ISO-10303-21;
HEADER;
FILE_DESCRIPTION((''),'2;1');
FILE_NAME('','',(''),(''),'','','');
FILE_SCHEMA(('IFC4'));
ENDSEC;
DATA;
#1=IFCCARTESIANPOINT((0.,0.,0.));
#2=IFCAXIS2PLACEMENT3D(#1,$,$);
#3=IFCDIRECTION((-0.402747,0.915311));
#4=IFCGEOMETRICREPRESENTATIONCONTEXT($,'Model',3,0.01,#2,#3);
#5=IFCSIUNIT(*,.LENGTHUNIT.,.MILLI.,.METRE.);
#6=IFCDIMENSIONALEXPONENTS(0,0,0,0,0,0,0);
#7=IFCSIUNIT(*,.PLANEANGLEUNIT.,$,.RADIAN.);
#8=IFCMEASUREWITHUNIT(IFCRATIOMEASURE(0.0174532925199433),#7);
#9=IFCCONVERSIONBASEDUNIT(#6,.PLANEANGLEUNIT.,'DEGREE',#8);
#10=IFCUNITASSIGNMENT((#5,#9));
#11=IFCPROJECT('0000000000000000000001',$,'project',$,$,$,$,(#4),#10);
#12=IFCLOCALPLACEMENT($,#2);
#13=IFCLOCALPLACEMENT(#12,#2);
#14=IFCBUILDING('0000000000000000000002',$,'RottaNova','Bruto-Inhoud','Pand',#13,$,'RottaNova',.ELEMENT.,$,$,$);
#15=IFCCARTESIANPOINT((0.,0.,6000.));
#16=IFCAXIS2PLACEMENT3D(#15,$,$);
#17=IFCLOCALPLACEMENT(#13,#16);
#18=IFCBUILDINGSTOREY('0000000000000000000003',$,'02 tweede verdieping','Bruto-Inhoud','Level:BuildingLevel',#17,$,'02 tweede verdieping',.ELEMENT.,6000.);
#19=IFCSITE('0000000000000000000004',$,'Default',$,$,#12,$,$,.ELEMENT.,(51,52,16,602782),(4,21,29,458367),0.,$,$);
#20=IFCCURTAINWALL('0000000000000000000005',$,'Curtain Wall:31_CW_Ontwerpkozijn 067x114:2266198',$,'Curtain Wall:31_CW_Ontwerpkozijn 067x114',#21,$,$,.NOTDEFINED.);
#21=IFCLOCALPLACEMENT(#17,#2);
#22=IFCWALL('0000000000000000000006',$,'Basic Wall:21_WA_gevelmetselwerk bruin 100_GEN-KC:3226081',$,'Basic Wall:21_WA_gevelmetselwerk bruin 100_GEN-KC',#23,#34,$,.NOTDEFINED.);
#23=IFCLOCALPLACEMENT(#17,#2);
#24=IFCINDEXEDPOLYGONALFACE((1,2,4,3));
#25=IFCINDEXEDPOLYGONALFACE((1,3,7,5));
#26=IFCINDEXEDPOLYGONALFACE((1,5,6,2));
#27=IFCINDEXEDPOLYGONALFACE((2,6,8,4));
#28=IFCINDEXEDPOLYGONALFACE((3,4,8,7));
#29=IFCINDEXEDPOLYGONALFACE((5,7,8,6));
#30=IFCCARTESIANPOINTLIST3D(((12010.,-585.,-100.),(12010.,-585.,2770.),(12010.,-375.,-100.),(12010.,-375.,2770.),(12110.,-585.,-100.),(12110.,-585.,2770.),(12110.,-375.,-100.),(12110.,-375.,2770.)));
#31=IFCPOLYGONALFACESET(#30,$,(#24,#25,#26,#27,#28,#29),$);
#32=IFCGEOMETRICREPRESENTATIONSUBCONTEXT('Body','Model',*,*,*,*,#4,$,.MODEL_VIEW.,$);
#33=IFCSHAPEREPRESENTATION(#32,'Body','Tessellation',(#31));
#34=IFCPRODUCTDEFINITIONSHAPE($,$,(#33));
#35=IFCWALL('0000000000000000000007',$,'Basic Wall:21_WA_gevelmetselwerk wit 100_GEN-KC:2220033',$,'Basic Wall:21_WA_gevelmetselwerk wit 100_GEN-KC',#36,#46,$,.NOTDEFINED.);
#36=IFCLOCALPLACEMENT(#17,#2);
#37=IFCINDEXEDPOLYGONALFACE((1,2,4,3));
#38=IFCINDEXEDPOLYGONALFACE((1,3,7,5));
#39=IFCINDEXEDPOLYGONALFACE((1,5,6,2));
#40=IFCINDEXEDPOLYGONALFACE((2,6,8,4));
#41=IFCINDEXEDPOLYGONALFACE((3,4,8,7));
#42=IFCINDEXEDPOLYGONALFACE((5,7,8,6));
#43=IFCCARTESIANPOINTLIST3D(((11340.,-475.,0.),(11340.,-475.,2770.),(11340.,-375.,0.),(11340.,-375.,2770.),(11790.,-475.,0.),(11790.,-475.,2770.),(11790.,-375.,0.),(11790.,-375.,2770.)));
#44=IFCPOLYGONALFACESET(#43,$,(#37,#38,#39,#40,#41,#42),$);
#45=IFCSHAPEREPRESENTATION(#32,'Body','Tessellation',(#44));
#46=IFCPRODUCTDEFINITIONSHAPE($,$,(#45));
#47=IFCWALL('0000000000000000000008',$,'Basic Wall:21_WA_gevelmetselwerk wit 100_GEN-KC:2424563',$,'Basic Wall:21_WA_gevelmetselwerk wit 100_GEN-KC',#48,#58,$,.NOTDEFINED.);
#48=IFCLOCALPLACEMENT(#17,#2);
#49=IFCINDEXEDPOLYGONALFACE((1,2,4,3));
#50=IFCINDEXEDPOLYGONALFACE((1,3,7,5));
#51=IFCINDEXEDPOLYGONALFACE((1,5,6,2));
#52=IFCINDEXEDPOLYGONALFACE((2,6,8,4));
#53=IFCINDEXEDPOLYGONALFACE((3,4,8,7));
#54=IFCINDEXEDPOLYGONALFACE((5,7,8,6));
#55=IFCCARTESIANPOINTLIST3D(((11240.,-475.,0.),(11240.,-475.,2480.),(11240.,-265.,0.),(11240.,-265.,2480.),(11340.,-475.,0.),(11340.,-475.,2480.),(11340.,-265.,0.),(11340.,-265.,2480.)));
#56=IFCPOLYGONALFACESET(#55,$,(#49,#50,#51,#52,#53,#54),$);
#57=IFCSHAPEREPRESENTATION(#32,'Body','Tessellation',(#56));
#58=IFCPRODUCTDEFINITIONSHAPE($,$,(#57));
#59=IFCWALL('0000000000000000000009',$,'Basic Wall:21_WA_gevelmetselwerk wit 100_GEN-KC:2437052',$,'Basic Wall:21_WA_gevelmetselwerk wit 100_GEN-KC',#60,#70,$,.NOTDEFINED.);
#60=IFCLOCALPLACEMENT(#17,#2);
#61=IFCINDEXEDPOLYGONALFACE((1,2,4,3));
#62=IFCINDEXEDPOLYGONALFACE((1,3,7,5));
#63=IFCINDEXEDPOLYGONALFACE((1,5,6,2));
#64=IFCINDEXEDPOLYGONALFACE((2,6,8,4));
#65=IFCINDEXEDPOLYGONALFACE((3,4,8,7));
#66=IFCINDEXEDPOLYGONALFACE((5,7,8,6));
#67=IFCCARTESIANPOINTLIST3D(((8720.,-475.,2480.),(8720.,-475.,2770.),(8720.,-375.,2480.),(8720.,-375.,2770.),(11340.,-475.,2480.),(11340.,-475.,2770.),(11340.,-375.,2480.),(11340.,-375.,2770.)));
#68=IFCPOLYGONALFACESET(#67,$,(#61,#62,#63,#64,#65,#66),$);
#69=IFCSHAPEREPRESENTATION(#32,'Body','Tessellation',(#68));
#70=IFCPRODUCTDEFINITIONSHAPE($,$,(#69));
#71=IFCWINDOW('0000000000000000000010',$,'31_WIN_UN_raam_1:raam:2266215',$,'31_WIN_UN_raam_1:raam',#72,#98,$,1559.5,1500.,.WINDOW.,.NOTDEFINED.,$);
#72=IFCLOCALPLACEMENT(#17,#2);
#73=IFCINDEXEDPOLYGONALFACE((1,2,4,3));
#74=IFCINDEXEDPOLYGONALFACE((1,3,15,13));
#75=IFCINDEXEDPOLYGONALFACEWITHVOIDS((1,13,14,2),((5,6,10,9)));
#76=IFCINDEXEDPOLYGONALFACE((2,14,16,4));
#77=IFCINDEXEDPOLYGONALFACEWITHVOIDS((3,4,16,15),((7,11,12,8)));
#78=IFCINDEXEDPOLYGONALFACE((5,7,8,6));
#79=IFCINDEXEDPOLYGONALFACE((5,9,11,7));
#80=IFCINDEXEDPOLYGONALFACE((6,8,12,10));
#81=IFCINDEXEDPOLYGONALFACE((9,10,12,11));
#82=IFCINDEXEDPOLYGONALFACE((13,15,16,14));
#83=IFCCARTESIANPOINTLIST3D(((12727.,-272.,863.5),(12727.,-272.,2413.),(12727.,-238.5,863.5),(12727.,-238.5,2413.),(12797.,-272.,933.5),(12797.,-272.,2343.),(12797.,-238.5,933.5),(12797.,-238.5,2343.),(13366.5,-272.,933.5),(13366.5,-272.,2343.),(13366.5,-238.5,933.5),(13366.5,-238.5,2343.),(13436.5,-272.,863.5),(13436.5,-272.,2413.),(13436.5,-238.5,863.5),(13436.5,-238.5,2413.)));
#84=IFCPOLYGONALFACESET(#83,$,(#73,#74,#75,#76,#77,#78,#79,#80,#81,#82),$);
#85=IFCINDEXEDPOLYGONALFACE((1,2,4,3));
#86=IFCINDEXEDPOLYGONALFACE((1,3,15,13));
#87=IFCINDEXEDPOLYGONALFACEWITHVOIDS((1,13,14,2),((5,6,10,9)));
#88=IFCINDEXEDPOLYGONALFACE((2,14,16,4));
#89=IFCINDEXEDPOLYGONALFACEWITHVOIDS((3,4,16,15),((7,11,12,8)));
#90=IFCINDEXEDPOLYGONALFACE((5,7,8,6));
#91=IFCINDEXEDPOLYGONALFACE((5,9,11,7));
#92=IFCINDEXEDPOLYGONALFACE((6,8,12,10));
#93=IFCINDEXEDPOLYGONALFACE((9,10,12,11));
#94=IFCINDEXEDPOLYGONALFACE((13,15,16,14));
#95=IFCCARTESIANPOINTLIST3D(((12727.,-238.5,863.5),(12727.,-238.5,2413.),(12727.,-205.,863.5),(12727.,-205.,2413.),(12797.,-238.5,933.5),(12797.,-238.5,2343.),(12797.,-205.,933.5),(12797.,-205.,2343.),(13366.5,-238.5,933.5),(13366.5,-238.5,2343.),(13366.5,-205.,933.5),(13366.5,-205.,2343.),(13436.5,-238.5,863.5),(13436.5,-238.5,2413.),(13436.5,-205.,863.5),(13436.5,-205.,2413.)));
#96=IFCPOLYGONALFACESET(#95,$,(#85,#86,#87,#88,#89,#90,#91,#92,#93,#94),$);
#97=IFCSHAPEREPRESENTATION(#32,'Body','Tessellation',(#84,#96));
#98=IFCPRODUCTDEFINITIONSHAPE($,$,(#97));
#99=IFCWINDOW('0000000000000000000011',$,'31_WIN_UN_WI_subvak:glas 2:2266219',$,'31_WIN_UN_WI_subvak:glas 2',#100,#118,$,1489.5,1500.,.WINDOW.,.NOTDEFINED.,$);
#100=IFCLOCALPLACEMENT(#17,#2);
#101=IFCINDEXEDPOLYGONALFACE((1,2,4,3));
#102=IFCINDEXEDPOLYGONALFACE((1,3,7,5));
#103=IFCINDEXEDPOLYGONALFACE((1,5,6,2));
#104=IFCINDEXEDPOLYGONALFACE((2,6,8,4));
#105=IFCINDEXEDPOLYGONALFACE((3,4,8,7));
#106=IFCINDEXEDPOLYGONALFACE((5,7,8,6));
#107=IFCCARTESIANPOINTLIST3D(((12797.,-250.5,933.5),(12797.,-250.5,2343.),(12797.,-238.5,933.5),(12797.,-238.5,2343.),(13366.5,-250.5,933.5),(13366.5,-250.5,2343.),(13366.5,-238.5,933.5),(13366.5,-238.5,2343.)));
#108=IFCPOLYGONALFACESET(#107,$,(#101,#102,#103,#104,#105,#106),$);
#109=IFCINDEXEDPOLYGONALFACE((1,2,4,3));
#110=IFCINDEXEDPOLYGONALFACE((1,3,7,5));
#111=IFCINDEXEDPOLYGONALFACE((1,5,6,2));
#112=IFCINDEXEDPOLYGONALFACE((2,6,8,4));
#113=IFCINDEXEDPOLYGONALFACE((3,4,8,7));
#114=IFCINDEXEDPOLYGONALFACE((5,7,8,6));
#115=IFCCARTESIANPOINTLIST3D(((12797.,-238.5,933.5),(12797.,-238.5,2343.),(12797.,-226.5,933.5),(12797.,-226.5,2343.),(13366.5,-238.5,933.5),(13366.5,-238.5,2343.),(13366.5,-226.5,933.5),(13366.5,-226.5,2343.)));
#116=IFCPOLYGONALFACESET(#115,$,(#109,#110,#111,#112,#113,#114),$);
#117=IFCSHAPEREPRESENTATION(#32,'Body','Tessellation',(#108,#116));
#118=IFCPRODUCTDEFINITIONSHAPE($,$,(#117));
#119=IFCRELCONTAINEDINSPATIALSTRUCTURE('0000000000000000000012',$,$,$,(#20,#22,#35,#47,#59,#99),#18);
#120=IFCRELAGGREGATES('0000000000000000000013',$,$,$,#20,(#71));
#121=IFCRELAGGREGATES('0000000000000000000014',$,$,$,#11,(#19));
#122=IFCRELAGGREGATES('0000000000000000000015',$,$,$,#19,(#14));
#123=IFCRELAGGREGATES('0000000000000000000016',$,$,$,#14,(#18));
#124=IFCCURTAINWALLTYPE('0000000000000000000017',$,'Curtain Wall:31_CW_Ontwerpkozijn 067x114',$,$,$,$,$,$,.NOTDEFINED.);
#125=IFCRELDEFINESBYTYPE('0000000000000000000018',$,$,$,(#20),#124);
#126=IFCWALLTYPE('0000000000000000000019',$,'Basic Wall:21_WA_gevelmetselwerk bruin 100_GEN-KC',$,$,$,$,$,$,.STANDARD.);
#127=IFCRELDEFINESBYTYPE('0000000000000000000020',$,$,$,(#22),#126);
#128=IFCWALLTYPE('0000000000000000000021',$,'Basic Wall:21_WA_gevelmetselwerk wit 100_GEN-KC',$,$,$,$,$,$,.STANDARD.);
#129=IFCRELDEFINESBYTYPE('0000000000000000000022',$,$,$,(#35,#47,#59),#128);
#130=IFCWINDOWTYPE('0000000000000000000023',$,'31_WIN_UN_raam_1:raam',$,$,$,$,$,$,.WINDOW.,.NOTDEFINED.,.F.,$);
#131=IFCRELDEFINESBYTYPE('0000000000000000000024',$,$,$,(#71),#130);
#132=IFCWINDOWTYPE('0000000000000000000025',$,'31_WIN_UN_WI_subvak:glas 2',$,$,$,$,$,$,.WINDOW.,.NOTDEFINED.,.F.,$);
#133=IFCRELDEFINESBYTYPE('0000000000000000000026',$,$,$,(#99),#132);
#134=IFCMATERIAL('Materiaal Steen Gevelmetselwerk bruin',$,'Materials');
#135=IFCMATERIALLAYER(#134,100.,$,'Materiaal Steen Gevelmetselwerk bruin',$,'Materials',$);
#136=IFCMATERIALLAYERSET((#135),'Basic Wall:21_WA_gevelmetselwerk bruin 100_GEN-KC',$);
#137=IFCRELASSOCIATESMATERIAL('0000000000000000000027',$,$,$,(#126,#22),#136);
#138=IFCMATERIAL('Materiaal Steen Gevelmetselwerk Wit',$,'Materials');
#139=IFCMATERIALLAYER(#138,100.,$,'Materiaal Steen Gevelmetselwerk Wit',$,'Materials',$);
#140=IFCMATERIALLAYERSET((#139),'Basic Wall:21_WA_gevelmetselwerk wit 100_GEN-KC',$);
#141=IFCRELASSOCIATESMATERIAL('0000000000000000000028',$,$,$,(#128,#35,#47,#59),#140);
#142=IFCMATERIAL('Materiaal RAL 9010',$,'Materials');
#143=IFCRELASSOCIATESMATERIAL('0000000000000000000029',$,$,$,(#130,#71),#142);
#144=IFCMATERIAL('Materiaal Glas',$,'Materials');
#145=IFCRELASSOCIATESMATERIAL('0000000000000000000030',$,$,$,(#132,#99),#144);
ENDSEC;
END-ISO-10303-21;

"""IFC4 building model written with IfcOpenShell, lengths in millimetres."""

from ifc_helpers import new_model, entity, si_unit, converted_unit, direction, frame, frame_2d, origin, origin_2d_with_axis, place, context, subcontext, project, spatial, polyline, rectangle, outline, extrude, clip, bounded_halfspace, source, transform, mapped, material, layer, layer_set, type_object, type_shapes, element, aggregate, save


model = new_model("IFC4")

# Units and contexts
model_context = context("Model", 3, precision=0.01, world=origin(), true_north=direction((-0.402747, 0.915311)))
body_context = subcontext(model_context, "Body", "Model", "MODEL_VIEW")
ifc_project = project(units=[si_unit("LENGTHUNIT", "METRE", prefix="MILLI"), converted_unit("PLANEANGLEUNIT", "DEGREE", entity("IfcRatioMeasure", 0.0174532925199433), si_unit("PLANEANGLEUNIT", "RADIAN"), dimensions=[0, 0, 0, 0, 0, 0, 0])], contexts=[model_context])

# Site, building, storey
site_placement = place(None, origin())
site = spatial("IfcSite", under=ifc_project, at=site_placement, Name="Default", CompositionType="ELEMENT", RefLatitude=(51, 52, 16, 602782), RefLongitude=(4, 21, 29, 458367), RefElevation=0.0)
building_placement = place(site_placement, origin())
building = spatial("IfcBuilding", under=site, at=building_placement, Name="RottaNova", Description="Bruto-Inhoud", ObjectType="Pand", LongName="RottaNova", CompositionType="ELEMENT")
storey_placement = place(building_placement, frame((0.0, 0.0, 6000.0)))
storey = spatial("IfcBuildingStorey", under=building, at=storey_placement, Name="02 tweede verdieping", Description="Bruto-Inhoud", ObjectType="Level:BuildingLevel", LongName="02 tweede verdieping", CompositionType="ELEMENT", Elevation=6000.0)

# Curtain wall
curtain_wall_type = type_object("IfcCurtainWallType", Name="Curtain Wall:31_CW_Ontwerpkozijn 067x114", PredefinedType="NOTDEFINED")
curtain_wall_1_placement = place(storey_placement, frame((0.0, 0.0, -6000.0)))
curtain_wall_1 = element("IfcCurtainWall", 1, at=curtain_wall_1_placement, inside=storey, type_object=curtain_wall_type, Name="Curtain Wall:31_CW_Ontwerpkozijn 067x114:2266198", ObjectType="Curtain Wall:31_CW_Ontwerpkozijn 067x114", PredefinedType="NOTDEFINED")
ifc_material_1 = material(Name="Materiaal RAL 9010", Category="Materials")

# Shared definitions
ifc_material_2 = material(Name="Materiaal Glas", Category="Materials")

# Wall
ifc_material_3 = material(Name="Materiaal Steen Gevelmetselwerk bruin", Category="Materials")
ifc_layer_1 = layer(ifc_material_3, 100.0, Name="Materiaal Steen Gevelmetselwerk bruin", Category="Materials")
ifc_layer_set_1 = layer_set([ifc_layer_1], Name="Basic Wall:21_WA_gevelmetselwerk bruin 100_GEN-KC")
wall_type_1 = type_object("IfcWallType", Name="Basic Wall:21_WA_gevelmetselwerk bruin 100_GEN-KC", PredefinedType="STANDARD", material=ifc_layer_set_1)
wall_1_placement = place(storey_placement, frame((12060.0, -585.0, -100.0), z_axis=(0.0, 0.0, 1.0), x_axis=(0.0, 1.0, 0.0)))
element("IfcWall", 2, at=wall_1_placement, inside=storey, type_object=wall_type_1, material=ifc_layer_set_1, Name="Basic Wall:21_WA_gevelmetselwerk bruin 100_GEN-KC:3226081", ObjectType="Basic Wall:21_WA_gevelmetselwerk bruin 100_GEN-KC", PredefinedType="NOTDEFINED", context=body_context, shape_type="SweptSolid", body=[
    extrude(rectangle(XDim=210.0, YDim=100.0, at=frame_2d((105.0, 0.0), x_axis=(-1.0, 0.0))), origin(), (0.0, 0.0, 1.0), 2870.0),
])

# Walls
ifc_material_4 = material(Name="Materiaal Steen Gevelmetselwerk Wit", Category="Materials")
ifc_layer_2 = layer(ifc_material_4, 100.0, Name="Materiaal Steen Gevelmetselwerk Wit", Category="Materials")
ifc_layer_set_2 = layer_set([ifc_layer_2], Name="Basic Wall:21_WA_gevelmetselwerk wit 100_GEN-KC")
wall_type_2 = type_object("IfcWallType", Name="Basic Wall:21_WA_gevelmetselwerk wit 100_GEN-KC", PredefinedType="STANDARD", material=ifc_layer_set_2)
wall_2_placement = place(storey_placement, frame((11790.0, -425.0, 0.0), z_axis=(0.0, 0.0, 1.0), x_axis=(-1.0, 0.0, 0.0)))
element("IfcWall", 3, at=wall_2_placement, inside=storey, type_object=wall_type_2, material=ifc_layer_set_2, Name="Basic Wall:21_WA_gevelmetselwerk wit 100_GEN-KC:2220033", ObjectType="Basic Wall:21_WA_gevelmetselwerk wit 100_GEN-KC", PredefinedType="NOTDEFINED", context=body_context, shape_type="SweptSolid", body=[
    extrude(rectangle(XDim=450.0, YDim=100.0, at=frame_2d((225.0, 0.0), x_axis=(-1.0, 0.0))), origin(), (0.0, 0.0, 1.0), 2770.0),
])
wall_3_placement = place(storey_placement, frame((11290.0, -265.0, 0.0), z_axis=(0.0, 0.0, 1.0), x_axis=(0.0, -1.0, 0.0)))
element("IfcWall", 4, at=wall_3_placement, inside=storey, type_object=wall_type_2, material=ifc_layer_set_2, Name="Basic Wall:21_WA_gevelmetselwerk wit 100_GEN-KC:2424563", ObjectType="Basic Wall:21_WA_gevelmetselwerk wit 100_GEN-KC", PredefinedType="NOTDEFINED", context=body_context, shape_type="SweptSolid", body=[
    extrude(rectangle(XDim=210.0, YDim=100.0, at=frame_2d((105.0, 0.0), x_axis=(-1.0, 0.0))), origin(), (0.0, 0.0, 1.0), 2480.0),
])
wall_4_placement = place(storey_placement, frame((11340.0, -425.0, 2480.0), z_axis=(0.0, 0.0, 1.0), x_axis=(-1.0, 0.0, 0.0)))
element("IfcWall", 5, at=wall_4_placement, inside=storey, type_object=wall_type_2, material=ifc_layer_set_2, Name="Basic Wall:21_WA_gevelmetselwerk wit 100_GEN-KC:2437052", ObjectType="Basic Wall:21_WA_gevelmetselwerk wit 100_GEN-KC", PredefinedType="NOTDEFINED", context=body_context, shape_type="Clipping", body=[
    clip(extrude(rectangle(XDim=2620.0, YDim=100.0, at=frame_2d((1310.0, 0.0), x_axis=(-1.0, 0.0))), origin(), (0.0, 0.0, 1.0), 290.0), bounded_halfspace(frame((2620.0, -50.0, 290.0), z_axis=(1.0, 0.0, 0.0), x_axis=(0.0, 1.0, 0.0)), False, frame((2620.0, -50.0, 290.0), z_axis=(1.0, 0.0, 0.0), x_axis=(0.0, 1.0, 0.0)), polyline([(0.0, 0.0), (0.0, -88392.0), (30480.0, -88392.0), (30480.0, 0.0), (0.0, 0.0)]))),
])

# Windows
window_type_1 = type_object("IfcWindowType", Name="31_WIN_UN_raam_1:raam", ParameterTakesPrecedence=False, PartitioningType="NOTDEFINED", PredefinedType="WINDOW", material=ifc_material_1)
shared_shape_1 = source(origin(), body_context, "Body", "SweptSolid", [
    extrude(outline(polyline([(-354.7, -774.7), (354.7, -774.7), (354.7, 774.7), (-354.7, 774.7), (-354.7, -774.7)]), holes=[polyline([(-284.7, 704.7), (284.7, 704.7), (284.7, -704.8), (-284.7, -704.8), (-284.7, 704.7)])]), frame((0.0, 92.0, 774.8), z_axis=(0.0, -1.0, 0.0), x_axis=(-1.0, 0.0, 0.0)), (0.0, 0.0, 1.0), 33.5),
    extrude(outline(polyline([(-354.7, -774.7), (354.7, -774.7), (354.7, 774.7), (-354.7, 774.7), (-354.7, -774.7)]), holes=[polyline([(-284.7, 704.7), (284.7, 704.7), (284.7, -704.8), (-284.7, -704.8), (-284.7, 704.7)])]), frame((0.0, 58.5, 774.8), z_axis=(0.0, -1.0, 0.0), x_axis=(-1.0, 0.0, 0.0)), (0.0, 0.0, 1.0), 33.5),
])
type_shapes(window_type_1, [shared_shape_1])
window_1_placement = place(curtain_wall_1_placement, frame((13081.8, -180.0, 6863.5), z_axis=(0.0, 0.0, 1.0), x_axis=(-1.0, 0.0, 0.0)))
window_1 = element("IfcWindow", 6, at=window_1_placement, type_object=window_type_1, material=ifc_material_1, Name="31_WIN_UN_raam_1:raam:2266215", ObjectType="31_WIN_UN_raam_1:raam", OverallHeight=1559.5, OverallWidth=1500.0, PartitioningType="NOTDEFINED", PredefinedType="WINDOW", context=body_context, shape_type="MappedRepresentation", body=[
    mapped(shared_shape_1, transform((0.0, 0.0, 0.0), scale=1.0)),
])
aggregate(curtain_wall_1, [window_1])
window_type_2 = type_object("IfcWindowType", Name="31_WIN_UN_WI_subvak:glas 2", ParameterTakesPrecedence=False, PartitioningType="NOTDEFINED", PredefinedType="WINDOW", material=ifc_material_2)
shared_shape_2 = source(origin(), body_context, "Body", "SweptSolid", [
    extrude(rectangle(XDim=569.5, YDim=12.0, at=origin_2d_with_axis()), frame((0.0, -6.0, 0.0)), (0.0, 0.0, 1.0), 1409.5),
    extrude(rectangle(XDim=569.5, YDim=12.0, at=origin_2d_with_axis()), frame((0.0, 6.0, 0.0)), (0.0, 0.0, 1.0), 1409.5),
])
type_shapes(window_type_2, [shared_shape_2])
window_2_placement = place(storey_placement, frame((13081.8, -238.5, 933.5)))
element("IfcWindow", 7, at=window_2_placement, inside=storey, type_object=window_type_2, material=ifc_material_2, Name="31_WIN_UN_WI_subvak:glas 2:2266219", ObjectType="31_WIN_UN_WI_subvak:glas 2", OverallHeight=1489.5, OverallWidth=1500.0, PartitioningType="NOTDEFINED", PredefinedType="WINDOW", context=body_context, shape_type="MappedRepresentation", body=[
    mapped(shared_shape_2, transform((0.0, 0.0, 0.0), scale=1.0)),
])

save(model, "model.ifc")
